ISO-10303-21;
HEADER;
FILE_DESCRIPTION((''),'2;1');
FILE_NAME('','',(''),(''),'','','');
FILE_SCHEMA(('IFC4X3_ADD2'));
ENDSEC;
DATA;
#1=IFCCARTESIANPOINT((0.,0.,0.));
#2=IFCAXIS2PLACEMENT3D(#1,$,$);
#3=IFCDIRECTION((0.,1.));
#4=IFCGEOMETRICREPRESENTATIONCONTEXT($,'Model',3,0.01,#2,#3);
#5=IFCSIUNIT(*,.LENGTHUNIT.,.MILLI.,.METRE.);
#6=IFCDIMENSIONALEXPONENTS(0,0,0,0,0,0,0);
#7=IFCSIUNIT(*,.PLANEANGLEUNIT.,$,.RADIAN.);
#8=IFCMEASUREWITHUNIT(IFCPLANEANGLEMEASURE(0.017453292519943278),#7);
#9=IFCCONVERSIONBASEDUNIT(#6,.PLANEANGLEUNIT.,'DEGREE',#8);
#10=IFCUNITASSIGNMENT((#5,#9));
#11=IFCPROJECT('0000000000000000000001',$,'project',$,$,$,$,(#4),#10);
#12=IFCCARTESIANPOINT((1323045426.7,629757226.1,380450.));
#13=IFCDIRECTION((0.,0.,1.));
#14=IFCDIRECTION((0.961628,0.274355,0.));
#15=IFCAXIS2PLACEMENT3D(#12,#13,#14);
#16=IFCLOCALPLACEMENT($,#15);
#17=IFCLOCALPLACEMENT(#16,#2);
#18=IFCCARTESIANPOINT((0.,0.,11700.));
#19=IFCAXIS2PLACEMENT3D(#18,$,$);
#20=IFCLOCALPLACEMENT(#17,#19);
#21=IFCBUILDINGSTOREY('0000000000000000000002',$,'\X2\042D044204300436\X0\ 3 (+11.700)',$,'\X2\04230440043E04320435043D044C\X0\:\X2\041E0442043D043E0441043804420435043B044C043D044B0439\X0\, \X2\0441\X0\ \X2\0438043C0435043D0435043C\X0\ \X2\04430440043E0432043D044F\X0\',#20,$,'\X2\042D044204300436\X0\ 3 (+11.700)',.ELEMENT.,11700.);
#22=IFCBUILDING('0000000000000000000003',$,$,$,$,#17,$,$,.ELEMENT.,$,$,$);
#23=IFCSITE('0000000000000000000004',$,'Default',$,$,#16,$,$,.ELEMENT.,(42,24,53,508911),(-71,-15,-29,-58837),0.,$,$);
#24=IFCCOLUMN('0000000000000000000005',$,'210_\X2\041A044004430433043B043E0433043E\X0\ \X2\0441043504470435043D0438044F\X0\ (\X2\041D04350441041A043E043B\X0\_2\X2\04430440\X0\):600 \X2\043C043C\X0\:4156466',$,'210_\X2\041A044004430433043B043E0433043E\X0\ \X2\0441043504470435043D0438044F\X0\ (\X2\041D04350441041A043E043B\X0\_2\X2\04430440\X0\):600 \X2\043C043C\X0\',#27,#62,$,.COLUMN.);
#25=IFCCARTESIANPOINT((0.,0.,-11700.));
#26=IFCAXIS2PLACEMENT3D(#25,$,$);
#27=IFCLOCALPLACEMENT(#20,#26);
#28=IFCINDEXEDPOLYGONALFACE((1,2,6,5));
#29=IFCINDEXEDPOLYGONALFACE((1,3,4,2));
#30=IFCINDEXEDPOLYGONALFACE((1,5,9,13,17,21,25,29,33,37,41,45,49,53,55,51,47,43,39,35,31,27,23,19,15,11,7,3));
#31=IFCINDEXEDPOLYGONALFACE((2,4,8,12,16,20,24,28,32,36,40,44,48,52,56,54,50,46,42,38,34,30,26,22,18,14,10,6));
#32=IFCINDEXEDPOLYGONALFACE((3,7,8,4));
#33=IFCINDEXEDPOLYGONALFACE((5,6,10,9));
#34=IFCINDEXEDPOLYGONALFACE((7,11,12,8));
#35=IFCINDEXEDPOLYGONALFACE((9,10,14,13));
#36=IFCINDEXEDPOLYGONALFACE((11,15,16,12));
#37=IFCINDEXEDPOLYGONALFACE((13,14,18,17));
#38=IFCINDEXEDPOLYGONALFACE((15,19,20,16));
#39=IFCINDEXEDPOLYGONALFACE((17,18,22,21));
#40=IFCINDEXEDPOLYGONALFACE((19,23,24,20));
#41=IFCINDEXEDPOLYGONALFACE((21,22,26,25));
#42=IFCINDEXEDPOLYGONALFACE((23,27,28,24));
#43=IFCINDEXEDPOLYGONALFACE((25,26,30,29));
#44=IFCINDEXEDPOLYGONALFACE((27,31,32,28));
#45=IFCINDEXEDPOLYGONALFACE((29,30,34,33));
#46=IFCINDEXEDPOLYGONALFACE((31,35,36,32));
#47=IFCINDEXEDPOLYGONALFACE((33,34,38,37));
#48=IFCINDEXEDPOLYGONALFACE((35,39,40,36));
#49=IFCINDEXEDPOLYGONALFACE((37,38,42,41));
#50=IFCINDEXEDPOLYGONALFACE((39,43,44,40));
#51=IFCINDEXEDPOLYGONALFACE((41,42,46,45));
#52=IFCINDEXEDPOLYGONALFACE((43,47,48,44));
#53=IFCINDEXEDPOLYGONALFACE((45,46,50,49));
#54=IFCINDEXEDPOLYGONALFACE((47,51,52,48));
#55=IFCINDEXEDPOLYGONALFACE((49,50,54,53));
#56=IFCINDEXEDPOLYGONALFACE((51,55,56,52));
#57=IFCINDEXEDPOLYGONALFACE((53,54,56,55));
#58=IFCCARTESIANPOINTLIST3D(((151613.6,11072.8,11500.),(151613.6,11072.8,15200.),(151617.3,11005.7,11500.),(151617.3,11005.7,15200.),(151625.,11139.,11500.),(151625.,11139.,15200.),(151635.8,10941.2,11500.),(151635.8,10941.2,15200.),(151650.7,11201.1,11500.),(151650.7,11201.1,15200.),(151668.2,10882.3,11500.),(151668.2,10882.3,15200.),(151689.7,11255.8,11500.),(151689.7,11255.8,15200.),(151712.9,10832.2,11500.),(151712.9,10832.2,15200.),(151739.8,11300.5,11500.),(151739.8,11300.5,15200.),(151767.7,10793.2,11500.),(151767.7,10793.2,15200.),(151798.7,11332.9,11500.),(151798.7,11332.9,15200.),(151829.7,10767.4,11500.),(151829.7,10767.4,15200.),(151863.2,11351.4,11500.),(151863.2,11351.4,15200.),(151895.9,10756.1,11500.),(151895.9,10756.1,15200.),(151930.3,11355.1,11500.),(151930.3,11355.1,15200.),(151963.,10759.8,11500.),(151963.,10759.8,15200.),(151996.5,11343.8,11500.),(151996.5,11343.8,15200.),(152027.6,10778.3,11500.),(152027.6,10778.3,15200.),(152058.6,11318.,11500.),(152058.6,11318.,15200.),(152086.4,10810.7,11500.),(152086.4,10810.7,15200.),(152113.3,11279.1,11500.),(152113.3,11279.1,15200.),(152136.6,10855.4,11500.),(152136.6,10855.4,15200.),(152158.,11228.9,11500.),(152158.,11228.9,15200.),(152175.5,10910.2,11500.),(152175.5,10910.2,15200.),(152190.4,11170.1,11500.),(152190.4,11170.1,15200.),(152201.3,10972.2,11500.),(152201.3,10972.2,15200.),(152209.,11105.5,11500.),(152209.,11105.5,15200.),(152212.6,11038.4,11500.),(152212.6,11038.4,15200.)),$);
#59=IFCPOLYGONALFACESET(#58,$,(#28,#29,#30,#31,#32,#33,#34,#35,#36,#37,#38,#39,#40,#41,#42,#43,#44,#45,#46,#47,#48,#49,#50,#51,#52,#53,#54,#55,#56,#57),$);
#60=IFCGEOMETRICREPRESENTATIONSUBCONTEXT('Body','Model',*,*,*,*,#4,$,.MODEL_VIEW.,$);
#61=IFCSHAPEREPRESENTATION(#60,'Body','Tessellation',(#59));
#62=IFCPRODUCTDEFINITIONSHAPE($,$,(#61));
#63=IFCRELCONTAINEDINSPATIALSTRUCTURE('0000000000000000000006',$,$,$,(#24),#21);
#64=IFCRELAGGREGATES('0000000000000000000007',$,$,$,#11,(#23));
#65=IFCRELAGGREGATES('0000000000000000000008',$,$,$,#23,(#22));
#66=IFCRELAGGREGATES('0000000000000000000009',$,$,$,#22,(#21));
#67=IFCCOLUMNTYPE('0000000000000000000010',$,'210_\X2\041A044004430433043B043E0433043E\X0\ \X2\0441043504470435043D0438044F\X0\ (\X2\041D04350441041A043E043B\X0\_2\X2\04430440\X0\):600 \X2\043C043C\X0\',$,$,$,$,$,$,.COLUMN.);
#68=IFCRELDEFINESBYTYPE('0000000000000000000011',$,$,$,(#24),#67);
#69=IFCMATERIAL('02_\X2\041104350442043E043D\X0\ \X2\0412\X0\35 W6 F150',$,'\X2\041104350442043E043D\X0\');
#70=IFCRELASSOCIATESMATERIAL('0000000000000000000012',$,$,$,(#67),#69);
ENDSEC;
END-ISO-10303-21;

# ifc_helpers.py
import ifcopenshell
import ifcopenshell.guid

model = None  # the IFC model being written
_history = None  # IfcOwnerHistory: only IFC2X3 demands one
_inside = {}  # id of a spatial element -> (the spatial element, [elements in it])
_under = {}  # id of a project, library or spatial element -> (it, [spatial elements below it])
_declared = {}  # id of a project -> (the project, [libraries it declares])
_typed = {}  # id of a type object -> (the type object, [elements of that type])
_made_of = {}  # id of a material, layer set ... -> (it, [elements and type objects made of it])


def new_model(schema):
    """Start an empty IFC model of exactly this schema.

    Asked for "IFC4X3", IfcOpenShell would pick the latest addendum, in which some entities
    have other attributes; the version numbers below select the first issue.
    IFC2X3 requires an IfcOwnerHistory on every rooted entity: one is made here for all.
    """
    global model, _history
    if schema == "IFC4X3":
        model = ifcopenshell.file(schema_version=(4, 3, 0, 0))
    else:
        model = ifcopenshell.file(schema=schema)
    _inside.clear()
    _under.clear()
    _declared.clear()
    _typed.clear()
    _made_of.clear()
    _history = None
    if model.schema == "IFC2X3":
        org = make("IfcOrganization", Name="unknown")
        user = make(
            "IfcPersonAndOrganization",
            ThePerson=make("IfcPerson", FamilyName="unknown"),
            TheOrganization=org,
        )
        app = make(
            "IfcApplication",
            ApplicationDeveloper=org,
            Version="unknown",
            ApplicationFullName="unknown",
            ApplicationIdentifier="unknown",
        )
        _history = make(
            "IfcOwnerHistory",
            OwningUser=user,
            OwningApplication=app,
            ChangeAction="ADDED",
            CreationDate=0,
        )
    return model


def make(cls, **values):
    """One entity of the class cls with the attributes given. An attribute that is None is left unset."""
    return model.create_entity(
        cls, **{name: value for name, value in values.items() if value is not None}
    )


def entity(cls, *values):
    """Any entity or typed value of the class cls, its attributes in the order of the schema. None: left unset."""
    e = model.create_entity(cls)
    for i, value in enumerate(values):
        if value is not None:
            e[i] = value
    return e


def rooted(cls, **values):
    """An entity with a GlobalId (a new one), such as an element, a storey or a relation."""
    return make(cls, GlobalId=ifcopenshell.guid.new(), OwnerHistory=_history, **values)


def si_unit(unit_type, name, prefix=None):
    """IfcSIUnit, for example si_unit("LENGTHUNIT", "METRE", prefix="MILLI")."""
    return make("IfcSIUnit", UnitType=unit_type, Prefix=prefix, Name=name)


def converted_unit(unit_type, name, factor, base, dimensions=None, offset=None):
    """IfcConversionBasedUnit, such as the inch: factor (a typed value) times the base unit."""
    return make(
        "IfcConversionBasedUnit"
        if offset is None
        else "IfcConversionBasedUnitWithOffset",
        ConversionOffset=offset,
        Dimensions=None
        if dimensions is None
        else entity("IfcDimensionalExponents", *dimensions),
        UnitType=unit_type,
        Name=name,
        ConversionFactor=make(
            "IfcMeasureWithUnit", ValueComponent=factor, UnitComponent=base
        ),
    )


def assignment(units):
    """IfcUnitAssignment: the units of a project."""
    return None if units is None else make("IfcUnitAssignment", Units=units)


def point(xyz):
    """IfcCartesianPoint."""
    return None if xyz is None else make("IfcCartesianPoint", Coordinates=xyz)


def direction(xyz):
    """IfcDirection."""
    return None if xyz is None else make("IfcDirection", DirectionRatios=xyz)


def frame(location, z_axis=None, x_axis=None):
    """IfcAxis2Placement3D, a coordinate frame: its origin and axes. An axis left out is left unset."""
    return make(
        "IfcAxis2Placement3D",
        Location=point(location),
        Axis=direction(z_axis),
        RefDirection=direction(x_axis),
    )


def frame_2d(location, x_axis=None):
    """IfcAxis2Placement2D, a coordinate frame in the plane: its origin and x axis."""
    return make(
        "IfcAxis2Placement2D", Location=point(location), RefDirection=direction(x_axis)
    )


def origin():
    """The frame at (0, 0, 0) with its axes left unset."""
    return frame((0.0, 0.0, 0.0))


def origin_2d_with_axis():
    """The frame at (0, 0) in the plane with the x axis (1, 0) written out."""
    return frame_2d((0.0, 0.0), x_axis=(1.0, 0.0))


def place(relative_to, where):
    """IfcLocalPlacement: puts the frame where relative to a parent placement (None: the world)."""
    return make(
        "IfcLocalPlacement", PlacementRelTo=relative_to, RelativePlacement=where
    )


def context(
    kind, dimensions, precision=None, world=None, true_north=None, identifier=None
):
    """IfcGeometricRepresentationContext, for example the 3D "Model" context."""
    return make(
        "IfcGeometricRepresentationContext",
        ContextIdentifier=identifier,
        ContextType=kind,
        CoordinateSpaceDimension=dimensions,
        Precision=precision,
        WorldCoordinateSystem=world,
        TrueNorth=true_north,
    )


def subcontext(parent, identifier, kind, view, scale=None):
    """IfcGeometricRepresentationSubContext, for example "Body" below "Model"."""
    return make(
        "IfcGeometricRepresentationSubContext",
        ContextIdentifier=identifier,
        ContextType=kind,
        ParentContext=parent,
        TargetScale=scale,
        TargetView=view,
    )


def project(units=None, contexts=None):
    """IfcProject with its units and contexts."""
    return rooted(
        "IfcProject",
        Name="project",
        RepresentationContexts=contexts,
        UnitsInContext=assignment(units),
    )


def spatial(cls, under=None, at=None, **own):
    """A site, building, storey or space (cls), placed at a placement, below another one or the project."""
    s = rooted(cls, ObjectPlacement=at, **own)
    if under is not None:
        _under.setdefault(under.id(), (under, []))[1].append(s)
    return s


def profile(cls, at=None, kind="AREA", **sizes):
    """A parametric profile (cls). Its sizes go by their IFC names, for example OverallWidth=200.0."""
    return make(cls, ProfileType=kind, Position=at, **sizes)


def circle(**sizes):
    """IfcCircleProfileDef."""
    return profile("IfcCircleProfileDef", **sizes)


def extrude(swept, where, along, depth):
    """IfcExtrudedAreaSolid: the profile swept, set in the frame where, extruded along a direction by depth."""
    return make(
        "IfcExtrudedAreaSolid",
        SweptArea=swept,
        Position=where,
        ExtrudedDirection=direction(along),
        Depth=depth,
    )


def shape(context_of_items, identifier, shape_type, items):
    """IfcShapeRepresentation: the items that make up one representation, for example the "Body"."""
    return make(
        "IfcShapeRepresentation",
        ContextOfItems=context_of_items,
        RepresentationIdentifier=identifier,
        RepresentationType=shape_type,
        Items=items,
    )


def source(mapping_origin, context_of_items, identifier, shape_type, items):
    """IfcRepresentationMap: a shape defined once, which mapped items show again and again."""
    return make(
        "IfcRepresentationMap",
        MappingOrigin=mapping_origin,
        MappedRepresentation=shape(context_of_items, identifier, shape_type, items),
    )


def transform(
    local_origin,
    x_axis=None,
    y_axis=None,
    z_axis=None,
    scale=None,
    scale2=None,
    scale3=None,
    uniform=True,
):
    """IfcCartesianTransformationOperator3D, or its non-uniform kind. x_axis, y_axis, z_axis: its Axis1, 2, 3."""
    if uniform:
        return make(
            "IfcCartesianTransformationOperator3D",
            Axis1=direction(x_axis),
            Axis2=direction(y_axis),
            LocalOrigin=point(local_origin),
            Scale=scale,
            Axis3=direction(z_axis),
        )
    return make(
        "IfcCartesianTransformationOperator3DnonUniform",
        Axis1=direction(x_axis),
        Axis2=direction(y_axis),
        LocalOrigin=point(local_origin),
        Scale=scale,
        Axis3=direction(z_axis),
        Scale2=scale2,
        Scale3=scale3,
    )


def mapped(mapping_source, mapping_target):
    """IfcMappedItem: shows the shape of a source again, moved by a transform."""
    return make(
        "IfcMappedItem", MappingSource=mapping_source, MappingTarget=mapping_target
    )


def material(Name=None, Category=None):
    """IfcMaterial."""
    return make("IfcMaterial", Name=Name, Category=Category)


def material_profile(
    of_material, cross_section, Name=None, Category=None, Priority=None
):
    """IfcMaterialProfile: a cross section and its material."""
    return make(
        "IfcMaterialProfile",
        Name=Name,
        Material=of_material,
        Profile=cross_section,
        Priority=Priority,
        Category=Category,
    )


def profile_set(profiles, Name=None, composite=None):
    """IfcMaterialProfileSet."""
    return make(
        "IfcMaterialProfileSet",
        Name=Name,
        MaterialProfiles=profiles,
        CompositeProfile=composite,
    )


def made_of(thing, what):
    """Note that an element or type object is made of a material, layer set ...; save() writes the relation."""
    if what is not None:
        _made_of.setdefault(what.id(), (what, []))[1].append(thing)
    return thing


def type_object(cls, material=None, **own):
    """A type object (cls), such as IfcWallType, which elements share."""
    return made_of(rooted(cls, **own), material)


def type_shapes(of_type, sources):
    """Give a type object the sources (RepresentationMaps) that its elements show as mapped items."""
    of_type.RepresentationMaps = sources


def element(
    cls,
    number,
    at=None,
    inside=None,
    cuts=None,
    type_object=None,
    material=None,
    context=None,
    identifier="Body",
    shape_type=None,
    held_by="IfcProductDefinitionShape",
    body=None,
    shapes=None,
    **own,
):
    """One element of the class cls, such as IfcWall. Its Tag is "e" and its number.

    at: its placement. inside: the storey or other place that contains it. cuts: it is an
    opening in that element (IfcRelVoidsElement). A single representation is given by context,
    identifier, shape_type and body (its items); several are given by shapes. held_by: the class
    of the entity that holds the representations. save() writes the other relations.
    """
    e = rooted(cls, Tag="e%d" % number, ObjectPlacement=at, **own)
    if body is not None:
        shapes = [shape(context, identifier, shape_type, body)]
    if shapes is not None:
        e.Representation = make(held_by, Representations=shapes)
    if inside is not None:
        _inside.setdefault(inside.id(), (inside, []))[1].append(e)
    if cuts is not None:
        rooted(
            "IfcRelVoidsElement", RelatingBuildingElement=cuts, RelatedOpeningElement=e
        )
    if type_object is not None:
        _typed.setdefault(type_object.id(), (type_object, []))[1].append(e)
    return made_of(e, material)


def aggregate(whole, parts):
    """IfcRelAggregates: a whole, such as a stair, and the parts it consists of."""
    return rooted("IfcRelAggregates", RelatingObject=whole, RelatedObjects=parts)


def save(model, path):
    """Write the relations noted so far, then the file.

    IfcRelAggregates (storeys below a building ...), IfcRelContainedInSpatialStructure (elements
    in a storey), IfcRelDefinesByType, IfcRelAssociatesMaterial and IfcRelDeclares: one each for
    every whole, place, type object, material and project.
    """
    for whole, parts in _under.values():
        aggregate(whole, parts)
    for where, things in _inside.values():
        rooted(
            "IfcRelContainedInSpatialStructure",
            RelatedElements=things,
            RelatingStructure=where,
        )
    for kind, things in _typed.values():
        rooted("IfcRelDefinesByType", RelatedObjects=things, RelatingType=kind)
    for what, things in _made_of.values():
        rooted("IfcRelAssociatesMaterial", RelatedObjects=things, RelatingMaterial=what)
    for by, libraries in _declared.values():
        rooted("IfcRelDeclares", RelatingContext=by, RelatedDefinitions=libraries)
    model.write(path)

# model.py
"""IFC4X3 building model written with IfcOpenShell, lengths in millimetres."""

from ifc_helpers import new_model, entity, si_unit, converted_unit, direction, frame, origin, origin_2d_with_axis, place, context, subcontext, project, spatial, circle, extrude, source, transform, mapped, material, material_profile, profile_set, type_object, type_shapes, element, save


model = new_model("IFC4X3")

# Units and contexts
model_context = context("Model", 3, precision=0.01, world=origin(), true_north=direction((0.0, 1.0)))
body_context = subcontext(model_context, "Body", "Model", "MODEL_VIEW")
ifc_project = project(units=[si_unit("LENGTHUNIT", "METRE", prefix="MILLI"), converted_unit("PLANEANGLEUNIT", "DEGREE", entity("IfcPlaneAngleMeasure", 0.017453292519943278), si_unit("PLANEANGLEUNIT", "RADIAN"), dimensions=[0, 0, 0, 0, 0, 0, 0])], contexts=[model_context])

# Site, building, storey
site_placement = place(None, frame((1323045426.7, 629757226.1, 380450.0), z_axis=(0.0, 0.0, 1.0), x_axis=(0.961628, 0.274355, 0.0)))
site = spatial("IfcSite", under=ifc_project, at=site_placement, Name="Default", CompositionType="ELEMENT", RefLatitude=(42, 24, 53, 508911), RefLongitude=(-71, -15, -29, -58837), RefElevation=0.0)
building_placement = place(site_placement, origin())
building = spatial("IfcBuilding", under=site, at=building_placement, CompositionType="ELEMENT")
storey_placement = place(building_placement, frame((0.0, 0.0, 11700.0)))
storey = spatial("IfcBuildingStorey", under=building, at=storey_placement, Name="Этаж 3 (+11.700)", ObjectType="Уровень:Относительный, с именем уровня", LongName="Этаж 3 (+11.700)", CompositionType="ELEMENT", Elevation=11700.0)

# Column
ifc_material_1 = material(Name="02_Бетон В35 W6 F150", Category="Бетон")
ifc_material_profile_1 = material_profile(ifc_material_1, circle(Radius=300.0, at=origin_2d_with_axis()), Name="600 мм")
ifc_profile_set_1 = profile_set([ifc_material_profile_1], Name="600 мм")
column_type_1 = type_object("IfcColumnType", Name="210_Круглого сечения (НесКол_2ур):600 мм", PredefinedType="COLUMN", material=ifc_profile_set_1)
shared_shape_1 = source(origin(), body_context, "Body", "SweptSolid", [
    extrude(circle(Radius=300.0, at=origin_2d_with_axis()), frame((151913.1, 11055.6, 11500.0), z_axis=(0.0, 0.0, 1.0), x_axis=(0.87462, -0.48481, 0.0)), (0.0, 0.0, 1.0), 3700.0),
])
type_shapes(column_type_1, [shared_shape_1])
column_1_placement = place(storey_placement, frame((0.0, 0.0, -11700.0)))
element("IfcColumn", 1, at=column_1_placement, inside=storey, type_object=column_type_1, Name="210_Круглого сечения (НесКол_2ур):600 мм:4156466", ObjectType="210_Круглого сечения (НесКол_2ур):600 мм", PredefinedType="COLUMN", context=body_context, shape_type="MappedRepresentation", body=[
    mapped(shared_shape_1, transform((0.0, 0.0, 0.0), scale=1.0)),
])

save(model, "model.ifc")
